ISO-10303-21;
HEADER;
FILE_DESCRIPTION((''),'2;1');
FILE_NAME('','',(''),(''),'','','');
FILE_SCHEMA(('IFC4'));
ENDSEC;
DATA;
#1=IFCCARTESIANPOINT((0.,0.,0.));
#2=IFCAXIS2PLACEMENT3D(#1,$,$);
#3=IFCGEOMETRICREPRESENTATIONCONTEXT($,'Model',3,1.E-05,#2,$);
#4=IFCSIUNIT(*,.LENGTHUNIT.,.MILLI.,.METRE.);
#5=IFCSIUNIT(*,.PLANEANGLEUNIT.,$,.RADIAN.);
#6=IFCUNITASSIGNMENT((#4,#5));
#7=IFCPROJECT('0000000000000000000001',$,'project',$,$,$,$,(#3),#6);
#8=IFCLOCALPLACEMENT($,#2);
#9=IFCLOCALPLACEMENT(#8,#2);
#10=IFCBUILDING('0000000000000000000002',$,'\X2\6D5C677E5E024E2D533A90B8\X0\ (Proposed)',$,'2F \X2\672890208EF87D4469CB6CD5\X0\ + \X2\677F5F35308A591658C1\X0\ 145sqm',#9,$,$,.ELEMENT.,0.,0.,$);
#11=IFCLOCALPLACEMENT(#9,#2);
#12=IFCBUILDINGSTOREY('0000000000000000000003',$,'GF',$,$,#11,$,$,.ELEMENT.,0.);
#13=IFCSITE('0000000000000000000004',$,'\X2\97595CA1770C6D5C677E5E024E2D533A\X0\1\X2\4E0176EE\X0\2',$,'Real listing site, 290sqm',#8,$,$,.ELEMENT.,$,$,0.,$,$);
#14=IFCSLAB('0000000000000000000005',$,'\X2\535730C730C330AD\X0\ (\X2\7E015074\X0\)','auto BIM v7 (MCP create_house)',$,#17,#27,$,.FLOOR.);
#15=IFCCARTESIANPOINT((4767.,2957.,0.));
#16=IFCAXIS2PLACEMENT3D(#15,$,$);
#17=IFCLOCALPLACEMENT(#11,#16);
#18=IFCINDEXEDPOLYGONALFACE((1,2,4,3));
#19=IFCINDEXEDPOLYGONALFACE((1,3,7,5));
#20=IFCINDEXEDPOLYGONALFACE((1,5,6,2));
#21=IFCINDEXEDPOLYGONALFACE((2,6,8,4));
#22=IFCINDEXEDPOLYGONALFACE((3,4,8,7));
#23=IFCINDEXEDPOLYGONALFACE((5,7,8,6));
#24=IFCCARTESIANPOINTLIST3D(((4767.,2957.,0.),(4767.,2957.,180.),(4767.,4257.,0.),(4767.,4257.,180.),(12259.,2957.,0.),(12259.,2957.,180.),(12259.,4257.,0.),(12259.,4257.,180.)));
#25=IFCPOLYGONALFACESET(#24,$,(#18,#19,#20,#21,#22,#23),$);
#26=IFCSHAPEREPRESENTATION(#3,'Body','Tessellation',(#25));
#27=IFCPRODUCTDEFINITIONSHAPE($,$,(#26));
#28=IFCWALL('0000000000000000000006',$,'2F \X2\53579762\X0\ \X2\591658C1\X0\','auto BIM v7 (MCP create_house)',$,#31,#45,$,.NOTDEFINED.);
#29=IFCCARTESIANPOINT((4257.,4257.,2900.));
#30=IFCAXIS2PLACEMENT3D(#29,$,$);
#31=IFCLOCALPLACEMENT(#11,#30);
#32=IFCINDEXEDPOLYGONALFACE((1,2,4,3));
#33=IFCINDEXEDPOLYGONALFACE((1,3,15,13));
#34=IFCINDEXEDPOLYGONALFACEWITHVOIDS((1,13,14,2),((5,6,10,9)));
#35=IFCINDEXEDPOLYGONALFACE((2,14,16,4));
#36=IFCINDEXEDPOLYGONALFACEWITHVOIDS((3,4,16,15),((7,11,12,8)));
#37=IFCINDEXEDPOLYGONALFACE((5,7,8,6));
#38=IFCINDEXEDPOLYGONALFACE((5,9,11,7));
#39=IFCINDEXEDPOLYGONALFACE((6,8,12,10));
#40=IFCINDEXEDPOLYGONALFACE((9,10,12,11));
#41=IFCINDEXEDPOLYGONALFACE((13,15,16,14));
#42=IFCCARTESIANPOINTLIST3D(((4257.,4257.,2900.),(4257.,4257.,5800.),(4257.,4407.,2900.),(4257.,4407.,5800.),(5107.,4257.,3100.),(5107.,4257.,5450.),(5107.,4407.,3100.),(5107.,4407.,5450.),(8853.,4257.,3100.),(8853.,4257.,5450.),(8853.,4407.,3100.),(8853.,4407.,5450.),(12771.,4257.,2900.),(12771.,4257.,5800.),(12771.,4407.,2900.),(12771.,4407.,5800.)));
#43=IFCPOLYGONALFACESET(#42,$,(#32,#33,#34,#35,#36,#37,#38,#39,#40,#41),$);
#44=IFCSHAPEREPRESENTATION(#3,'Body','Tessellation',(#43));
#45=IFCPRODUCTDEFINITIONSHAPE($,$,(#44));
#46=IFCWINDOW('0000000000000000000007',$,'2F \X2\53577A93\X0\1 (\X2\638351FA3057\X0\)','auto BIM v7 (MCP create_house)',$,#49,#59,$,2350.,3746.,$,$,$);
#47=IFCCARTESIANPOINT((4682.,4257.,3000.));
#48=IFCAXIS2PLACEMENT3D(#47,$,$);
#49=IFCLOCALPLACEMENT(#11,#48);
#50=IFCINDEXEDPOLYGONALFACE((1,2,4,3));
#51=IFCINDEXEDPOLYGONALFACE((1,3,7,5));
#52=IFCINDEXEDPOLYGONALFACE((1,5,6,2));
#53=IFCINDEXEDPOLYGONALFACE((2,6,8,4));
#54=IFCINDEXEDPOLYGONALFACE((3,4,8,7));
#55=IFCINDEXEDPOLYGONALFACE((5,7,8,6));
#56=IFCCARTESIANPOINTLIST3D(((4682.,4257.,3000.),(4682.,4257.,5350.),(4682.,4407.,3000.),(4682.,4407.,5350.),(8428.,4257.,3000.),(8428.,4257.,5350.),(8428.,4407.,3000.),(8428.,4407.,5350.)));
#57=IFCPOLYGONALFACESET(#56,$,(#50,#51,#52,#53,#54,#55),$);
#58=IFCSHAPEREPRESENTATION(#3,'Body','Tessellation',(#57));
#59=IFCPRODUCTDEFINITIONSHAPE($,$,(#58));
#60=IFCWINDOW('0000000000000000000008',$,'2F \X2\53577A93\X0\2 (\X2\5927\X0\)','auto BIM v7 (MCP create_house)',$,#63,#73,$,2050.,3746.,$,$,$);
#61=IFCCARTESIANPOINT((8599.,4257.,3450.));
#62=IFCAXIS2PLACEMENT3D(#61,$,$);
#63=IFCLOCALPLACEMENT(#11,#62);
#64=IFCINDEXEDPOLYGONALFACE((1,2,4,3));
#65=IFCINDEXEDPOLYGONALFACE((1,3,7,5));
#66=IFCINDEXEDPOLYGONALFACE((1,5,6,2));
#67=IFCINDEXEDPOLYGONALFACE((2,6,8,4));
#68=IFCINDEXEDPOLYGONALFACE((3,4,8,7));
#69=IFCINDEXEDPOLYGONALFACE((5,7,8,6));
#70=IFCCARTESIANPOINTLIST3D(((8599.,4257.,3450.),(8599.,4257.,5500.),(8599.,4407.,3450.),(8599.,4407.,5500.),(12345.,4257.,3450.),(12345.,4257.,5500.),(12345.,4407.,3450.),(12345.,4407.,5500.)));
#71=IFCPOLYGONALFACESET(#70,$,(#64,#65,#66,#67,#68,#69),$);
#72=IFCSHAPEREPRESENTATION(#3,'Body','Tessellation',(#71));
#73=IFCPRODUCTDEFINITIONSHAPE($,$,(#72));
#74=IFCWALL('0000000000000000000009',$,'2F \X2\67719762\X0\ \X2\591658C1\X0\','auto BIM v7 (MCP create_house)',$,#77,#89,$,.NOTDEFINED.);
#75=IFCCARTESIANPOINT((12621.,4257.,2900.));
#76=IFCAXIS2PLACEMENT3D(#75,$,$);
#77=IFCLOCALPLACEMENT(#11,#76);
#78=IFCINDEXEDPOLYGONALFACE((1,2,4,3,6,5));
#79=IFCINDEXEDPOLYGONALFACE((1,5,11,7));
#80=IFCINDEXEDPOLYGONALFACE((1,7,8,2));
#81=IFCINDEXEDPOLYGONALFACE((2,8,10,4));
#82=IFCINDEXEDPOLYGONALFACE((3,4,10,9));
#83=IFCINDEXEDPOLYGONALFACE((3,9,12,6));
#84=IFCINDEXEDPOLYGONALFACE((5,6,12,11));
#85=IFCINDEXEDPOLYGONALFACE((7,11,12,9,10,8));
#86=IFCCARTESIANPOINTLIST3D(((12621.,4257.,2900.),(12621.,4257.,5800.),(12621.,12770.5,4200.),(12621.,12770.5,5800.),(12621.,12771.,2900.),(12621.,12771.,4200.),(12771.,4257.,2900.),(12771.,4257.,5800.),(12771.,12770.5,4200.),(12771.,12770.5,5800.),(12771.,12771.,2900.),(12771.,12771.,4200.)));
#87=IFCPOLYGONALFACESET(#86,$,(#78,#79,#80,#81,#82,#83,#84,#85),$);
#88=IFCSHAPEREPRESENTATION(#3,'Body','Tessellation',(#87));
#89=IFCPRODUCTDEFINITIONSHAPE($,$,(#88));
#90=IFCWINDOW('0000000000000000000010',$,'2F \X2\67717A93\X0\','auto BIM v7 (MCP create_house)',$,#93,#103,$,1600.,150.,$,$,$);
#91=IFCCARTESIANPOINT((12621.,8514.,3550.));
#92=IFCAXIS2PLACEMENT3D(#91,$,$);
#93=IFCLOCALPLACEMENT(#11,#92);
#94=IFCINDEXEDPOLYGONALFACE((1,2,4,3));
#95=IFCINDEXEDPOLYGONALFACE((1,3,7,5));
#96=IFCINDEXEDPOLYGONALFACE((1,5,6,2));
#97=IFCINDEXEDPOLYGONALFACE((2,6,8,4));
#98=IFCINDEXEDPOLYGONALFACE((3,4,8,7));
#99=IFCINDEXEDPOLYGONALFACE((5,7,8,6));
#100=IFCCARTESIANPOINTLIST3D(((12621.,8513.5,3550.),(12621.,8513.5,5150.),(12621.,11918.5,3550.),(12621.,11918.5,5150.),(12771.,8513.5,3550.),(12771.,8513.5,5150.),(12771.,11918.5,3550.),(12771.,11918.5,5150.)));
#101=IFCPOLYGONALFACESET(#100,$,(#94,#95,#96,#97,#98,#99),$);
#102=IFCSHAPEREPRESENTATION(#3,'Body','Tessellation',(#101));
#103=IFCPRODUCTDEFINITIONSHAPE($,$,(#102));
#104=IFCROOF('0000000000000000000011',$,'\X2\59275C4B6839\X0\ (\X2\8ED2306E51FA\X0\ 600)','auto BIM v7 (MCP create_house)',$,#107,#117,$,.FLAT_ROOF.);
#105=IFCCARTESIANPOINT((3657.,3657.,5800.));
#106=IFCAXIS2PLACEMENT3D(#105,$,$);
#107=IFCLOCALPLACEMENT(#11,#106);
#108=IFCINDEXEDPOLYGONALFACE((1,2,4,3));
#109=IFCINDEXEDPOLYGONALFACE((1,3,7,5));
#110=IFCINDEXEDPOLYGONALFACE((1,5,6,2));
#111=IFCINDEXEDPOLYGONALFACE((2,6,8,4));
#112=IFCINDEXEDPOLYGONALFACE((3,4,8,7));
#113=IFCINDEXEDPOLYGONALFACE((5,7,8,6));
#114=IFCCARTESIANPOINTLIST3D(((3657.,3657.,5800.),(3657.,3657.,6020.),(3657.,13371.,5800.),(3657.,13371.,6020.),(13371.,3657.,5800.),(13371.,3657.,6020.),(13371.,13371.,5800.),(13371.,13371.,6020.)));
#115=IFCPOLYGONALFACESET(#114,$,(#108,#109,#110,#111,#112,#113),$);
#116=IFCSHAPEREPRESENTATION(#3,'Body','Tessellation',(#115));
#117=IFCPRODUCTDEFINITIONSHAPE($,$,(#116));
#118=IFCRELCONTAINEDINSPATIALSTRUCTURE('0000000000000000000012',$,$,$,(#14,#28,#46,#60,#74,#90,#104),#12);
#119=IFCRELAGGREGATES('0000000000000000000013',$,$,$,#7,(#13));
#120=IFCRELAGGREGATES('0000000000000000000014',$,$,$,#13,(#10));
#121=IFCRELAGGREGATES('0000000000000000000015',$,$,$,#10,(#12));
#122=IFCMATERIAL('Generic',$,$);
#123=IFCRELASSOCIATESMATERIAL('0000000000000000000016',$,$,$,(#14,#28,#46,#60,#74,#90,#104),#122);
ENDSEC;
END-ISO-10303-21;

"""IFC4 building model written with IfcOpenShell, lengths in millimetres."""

from ifc_helpers import new_model, si_unit, frame, frame_2d, origin, place, context, project, spatial, rectangle, extrude, material, element, fill, save


model = new_model("IFC4")

# Units and contexts
model_context = context("Model", 3, precision=1e-05, world=origin())
ifc_project = project(units=[si_unit("LENGTHUNIT", "METRE", prefix="MILLI"), si_unit("PLANEANGLEUNIT", "RADIAN")], contexts=[model_context])

# Site, building, storey
site_placement = place(None, origin())
site = spatial("IfcSite", under=ifc_project, at=site_placement, Name="静岡県浜松市中区1丁目2", ObjectType="Real listing site, 290sqm", CompositionType="ELEMENT", RefElevation=0.0)
building_placement = place(site_placement, origin())
building = spatial("IfcBuilding", under=site, at=building_placement, Name="浜松市中区邸 (Proposed)", ObjectType="2F 木造軸組構法 + 板張り外壁 145sqm", CompositionType="ELEMENT", ElevationOfRefHeight=0.0, ElevationOfTerrain=0.0)
storey_placement = place(building_placement, origin())
storey = spatial("IfcBuildingStorey", under=building, at=storey_placement, Name="GF", CompositionType="ELEMENT", Elevation=0.0)

# Slab
ifc_material = material(Name="Generic")
slab_1_placement = place(storey_placement, frame((4767.0, 2957.0, 0.0)))
element("IfcSlab", 1, at=slab_1_placement, inside=storey, material=ifc_material, Name="南デッキ (縁側)", Description="auto BIM v7 (MCP create_house)", PredefinedType="FLOOR", context=model_context, shape_type="SweptSolid", body=[
    extrude(rectangle(XDim=7492.0, YDim=1300.0, at=frame_2d((3746.0, 650.0))), frame((4767.0, 2957.0, 0.0)), (0.0, 0.0, 1.0), 180.0),
])

# Wall, openings, windows
wall_1_placement = place(storey_placement, frame((4257.0, 4257.0, 2900.0)))
wall_1 = element("IfcWall", 2, at=wall_1_placement, inside=storey, material=ifc_material, Name="2F 南面 外壁", Description="auto BIM v7 (MCP create_house)", PredefinedType="NOTDEFINED", context=model_context, shape_type="SweptSolid", body=[
    extrude(rectangle(XDim=8514.0, YDim=150.0, at=frame_2d((4257.0, 75.0))), frame((4257.0, 4257.0, 2900.0)), (0.0, 0.0, 1.0), 2900.0),
])
opening_1_placement = place(storey_placement, frame((4682.0, 4257.0, 3000.0)))
opening_1 = element("IfcOpeningElement", 3, at=opening_1_placement, cuts=wall_1, PredefinedType="NOTDEFINED", context=model_context, shape_type="SweptSolid", body=[
    extrude(rectangle(XDim=3746.0, YDim=150.0, at=frame_2d((1873.0, 75.0))), frame((4682.0, 4257.0, 3000.0)), (0.0, 0.0, 1.0), 2350.0),
])
opening_2_placement = place(storey_placement, frame((8599.0, 4257.0, 3450.0)))
opening_2 = element("IfcOpeningElement", 4, at=opening_2_placement, cuts=wall_1, PredefinedType="NOTDEFINED", context=model_context, shape_type="SweptSolid", body=[
    extrude(rectangle(XDim=3746.0, YDim=150.0, at=frame_2d((1873.0, 75.0))), frame((8599.0, 4257.0, 3450.0)), (0.0, 0.0, 1.0), 2050.0),
])
window_1_placement = place(storey_placement, frame((4682.0, 4257.0, 3000.0)))
window_1 = element("IfcWindow", 5, at=window_1_placement, inside=storey, material=ifc_material, Name="2F 南窓1 (掃出し)", Description="auto BIM v7 (MCP create_house)", OverallHeight=2350.0, OverallWidth=3746.0, context=model_context, shape_type="SweptSolid", body=[
    extrude(rectangle(XDim=3746.0, YDim=150.0, at=frame_2d((1873.0, 75.0))), frame((4682.0, 4257.0, 3000.0)), (0.0, 0.0, 1.0), 2350.0),
])
fill(opening_1, window_1)
window_2_placement = place(storey_placement, frame((8599.0, 4257.0, 3450.0)))
window_2 = element("IfcWindow", 6, at=window_2_placement, inside=storey, material=ifc_material, Name="2F 南窓2 (大)", Description="auto BIM v7 (MCP create_house)", OverallHeight=2050.0, OverallWidth=3746.0, context=model_context, shape_type="SweptSolid", body=[
    extrude(rectangle(XDim=3746.0, YDim=150.0, at=frame_2d((1873.0, 75.0))), frame((8599.0, 4257.0, 3450.0)), (0.0, 0.0, 1.0), 2050.0),
])
fill(opening_2, window_2)

# Wall, opening, window
wall_2_placement = place(storey_placement, frame((12621.0, 4257.0, 2900.0)))
wall_2 = element("IfcWall", 7, at=wall_2_placement, inside=storey, material=ifc_material, Name="2F 東面 外壁", Description="auto BIM v7 (MCP create_house)", PredefinedType="NOTDEFINED", context=model_context, shape_type="SweptSolid", body=[
    extrude(rectangle(XDim=150.0, YDim=8514.0, at=frame_2d((75.0, 4257.0))), frame((12621.0, 4257.0, 2900.0)), (0.0, 0.0, 1.0), 2900.0),
])
opening_3_placement = place(storey_placement, frame((12621.0, 8514.0, 3550.0)))
opening_3 = element("IfcOpeningElement", 8, at=opening_3_placement, cuts=wall_2, PredefinedType="NOTDEFINED", context=model_context, shape_type="SweptSolid", body=[
    extrude(rectangle(XDim=150.0, YDim=3405.0, at=frame_2d((75.0, 1702.0))), frame((12621.0, 8514.0, 3550.0)), (0.0, 0.0, 1.0), 1600.0),
])
window_3_placement = place(storey_placement, frame((12621.0, 8514.0, 3550.0)))
window_3 = element("IfcWindow", 9, at=window_3_placement, inside=storey, material=ifc_material, Name="2F 東窓", Description="auto BIM v7 (MCP create_house)", OverallHeight=1600.0, OverallWidth=150.0, context=model_context, shape_type="SweptSolid", body=[
    extrude(rectangle(XDim=150.0, YDim=3405.0, at=frame_2d((75.0, 1702.0))), frame((12621.0, 8514.0, 3550.0)), (0.0, 0.0, 1.0), 1600.0),
])
fill(opening_3, window_3)

# Roof
roof_placement = place(storey_placement, frame((3657.0, 3657.0, 5800.0)))
element("IfcRoof", 10, at=roof_placement, inside=storey, material=ifc_material, Name="大屋根 (軒の出 600)", Description="auto BIM v7 (MCP create_house)", PredefinedType="FLAT_ROOF", context=model_context, shape_type="SweptSolid", body=[
    extrude(rectangle(XDim=9714.0, YDim=9714.0, at=frame_2d((4857.0, 4857.0))), frame((3657.0, 3657.0, 5800.0)), (0.0, 0.0, 1.0), 220.0),
])

save(model, "model.ifc")
